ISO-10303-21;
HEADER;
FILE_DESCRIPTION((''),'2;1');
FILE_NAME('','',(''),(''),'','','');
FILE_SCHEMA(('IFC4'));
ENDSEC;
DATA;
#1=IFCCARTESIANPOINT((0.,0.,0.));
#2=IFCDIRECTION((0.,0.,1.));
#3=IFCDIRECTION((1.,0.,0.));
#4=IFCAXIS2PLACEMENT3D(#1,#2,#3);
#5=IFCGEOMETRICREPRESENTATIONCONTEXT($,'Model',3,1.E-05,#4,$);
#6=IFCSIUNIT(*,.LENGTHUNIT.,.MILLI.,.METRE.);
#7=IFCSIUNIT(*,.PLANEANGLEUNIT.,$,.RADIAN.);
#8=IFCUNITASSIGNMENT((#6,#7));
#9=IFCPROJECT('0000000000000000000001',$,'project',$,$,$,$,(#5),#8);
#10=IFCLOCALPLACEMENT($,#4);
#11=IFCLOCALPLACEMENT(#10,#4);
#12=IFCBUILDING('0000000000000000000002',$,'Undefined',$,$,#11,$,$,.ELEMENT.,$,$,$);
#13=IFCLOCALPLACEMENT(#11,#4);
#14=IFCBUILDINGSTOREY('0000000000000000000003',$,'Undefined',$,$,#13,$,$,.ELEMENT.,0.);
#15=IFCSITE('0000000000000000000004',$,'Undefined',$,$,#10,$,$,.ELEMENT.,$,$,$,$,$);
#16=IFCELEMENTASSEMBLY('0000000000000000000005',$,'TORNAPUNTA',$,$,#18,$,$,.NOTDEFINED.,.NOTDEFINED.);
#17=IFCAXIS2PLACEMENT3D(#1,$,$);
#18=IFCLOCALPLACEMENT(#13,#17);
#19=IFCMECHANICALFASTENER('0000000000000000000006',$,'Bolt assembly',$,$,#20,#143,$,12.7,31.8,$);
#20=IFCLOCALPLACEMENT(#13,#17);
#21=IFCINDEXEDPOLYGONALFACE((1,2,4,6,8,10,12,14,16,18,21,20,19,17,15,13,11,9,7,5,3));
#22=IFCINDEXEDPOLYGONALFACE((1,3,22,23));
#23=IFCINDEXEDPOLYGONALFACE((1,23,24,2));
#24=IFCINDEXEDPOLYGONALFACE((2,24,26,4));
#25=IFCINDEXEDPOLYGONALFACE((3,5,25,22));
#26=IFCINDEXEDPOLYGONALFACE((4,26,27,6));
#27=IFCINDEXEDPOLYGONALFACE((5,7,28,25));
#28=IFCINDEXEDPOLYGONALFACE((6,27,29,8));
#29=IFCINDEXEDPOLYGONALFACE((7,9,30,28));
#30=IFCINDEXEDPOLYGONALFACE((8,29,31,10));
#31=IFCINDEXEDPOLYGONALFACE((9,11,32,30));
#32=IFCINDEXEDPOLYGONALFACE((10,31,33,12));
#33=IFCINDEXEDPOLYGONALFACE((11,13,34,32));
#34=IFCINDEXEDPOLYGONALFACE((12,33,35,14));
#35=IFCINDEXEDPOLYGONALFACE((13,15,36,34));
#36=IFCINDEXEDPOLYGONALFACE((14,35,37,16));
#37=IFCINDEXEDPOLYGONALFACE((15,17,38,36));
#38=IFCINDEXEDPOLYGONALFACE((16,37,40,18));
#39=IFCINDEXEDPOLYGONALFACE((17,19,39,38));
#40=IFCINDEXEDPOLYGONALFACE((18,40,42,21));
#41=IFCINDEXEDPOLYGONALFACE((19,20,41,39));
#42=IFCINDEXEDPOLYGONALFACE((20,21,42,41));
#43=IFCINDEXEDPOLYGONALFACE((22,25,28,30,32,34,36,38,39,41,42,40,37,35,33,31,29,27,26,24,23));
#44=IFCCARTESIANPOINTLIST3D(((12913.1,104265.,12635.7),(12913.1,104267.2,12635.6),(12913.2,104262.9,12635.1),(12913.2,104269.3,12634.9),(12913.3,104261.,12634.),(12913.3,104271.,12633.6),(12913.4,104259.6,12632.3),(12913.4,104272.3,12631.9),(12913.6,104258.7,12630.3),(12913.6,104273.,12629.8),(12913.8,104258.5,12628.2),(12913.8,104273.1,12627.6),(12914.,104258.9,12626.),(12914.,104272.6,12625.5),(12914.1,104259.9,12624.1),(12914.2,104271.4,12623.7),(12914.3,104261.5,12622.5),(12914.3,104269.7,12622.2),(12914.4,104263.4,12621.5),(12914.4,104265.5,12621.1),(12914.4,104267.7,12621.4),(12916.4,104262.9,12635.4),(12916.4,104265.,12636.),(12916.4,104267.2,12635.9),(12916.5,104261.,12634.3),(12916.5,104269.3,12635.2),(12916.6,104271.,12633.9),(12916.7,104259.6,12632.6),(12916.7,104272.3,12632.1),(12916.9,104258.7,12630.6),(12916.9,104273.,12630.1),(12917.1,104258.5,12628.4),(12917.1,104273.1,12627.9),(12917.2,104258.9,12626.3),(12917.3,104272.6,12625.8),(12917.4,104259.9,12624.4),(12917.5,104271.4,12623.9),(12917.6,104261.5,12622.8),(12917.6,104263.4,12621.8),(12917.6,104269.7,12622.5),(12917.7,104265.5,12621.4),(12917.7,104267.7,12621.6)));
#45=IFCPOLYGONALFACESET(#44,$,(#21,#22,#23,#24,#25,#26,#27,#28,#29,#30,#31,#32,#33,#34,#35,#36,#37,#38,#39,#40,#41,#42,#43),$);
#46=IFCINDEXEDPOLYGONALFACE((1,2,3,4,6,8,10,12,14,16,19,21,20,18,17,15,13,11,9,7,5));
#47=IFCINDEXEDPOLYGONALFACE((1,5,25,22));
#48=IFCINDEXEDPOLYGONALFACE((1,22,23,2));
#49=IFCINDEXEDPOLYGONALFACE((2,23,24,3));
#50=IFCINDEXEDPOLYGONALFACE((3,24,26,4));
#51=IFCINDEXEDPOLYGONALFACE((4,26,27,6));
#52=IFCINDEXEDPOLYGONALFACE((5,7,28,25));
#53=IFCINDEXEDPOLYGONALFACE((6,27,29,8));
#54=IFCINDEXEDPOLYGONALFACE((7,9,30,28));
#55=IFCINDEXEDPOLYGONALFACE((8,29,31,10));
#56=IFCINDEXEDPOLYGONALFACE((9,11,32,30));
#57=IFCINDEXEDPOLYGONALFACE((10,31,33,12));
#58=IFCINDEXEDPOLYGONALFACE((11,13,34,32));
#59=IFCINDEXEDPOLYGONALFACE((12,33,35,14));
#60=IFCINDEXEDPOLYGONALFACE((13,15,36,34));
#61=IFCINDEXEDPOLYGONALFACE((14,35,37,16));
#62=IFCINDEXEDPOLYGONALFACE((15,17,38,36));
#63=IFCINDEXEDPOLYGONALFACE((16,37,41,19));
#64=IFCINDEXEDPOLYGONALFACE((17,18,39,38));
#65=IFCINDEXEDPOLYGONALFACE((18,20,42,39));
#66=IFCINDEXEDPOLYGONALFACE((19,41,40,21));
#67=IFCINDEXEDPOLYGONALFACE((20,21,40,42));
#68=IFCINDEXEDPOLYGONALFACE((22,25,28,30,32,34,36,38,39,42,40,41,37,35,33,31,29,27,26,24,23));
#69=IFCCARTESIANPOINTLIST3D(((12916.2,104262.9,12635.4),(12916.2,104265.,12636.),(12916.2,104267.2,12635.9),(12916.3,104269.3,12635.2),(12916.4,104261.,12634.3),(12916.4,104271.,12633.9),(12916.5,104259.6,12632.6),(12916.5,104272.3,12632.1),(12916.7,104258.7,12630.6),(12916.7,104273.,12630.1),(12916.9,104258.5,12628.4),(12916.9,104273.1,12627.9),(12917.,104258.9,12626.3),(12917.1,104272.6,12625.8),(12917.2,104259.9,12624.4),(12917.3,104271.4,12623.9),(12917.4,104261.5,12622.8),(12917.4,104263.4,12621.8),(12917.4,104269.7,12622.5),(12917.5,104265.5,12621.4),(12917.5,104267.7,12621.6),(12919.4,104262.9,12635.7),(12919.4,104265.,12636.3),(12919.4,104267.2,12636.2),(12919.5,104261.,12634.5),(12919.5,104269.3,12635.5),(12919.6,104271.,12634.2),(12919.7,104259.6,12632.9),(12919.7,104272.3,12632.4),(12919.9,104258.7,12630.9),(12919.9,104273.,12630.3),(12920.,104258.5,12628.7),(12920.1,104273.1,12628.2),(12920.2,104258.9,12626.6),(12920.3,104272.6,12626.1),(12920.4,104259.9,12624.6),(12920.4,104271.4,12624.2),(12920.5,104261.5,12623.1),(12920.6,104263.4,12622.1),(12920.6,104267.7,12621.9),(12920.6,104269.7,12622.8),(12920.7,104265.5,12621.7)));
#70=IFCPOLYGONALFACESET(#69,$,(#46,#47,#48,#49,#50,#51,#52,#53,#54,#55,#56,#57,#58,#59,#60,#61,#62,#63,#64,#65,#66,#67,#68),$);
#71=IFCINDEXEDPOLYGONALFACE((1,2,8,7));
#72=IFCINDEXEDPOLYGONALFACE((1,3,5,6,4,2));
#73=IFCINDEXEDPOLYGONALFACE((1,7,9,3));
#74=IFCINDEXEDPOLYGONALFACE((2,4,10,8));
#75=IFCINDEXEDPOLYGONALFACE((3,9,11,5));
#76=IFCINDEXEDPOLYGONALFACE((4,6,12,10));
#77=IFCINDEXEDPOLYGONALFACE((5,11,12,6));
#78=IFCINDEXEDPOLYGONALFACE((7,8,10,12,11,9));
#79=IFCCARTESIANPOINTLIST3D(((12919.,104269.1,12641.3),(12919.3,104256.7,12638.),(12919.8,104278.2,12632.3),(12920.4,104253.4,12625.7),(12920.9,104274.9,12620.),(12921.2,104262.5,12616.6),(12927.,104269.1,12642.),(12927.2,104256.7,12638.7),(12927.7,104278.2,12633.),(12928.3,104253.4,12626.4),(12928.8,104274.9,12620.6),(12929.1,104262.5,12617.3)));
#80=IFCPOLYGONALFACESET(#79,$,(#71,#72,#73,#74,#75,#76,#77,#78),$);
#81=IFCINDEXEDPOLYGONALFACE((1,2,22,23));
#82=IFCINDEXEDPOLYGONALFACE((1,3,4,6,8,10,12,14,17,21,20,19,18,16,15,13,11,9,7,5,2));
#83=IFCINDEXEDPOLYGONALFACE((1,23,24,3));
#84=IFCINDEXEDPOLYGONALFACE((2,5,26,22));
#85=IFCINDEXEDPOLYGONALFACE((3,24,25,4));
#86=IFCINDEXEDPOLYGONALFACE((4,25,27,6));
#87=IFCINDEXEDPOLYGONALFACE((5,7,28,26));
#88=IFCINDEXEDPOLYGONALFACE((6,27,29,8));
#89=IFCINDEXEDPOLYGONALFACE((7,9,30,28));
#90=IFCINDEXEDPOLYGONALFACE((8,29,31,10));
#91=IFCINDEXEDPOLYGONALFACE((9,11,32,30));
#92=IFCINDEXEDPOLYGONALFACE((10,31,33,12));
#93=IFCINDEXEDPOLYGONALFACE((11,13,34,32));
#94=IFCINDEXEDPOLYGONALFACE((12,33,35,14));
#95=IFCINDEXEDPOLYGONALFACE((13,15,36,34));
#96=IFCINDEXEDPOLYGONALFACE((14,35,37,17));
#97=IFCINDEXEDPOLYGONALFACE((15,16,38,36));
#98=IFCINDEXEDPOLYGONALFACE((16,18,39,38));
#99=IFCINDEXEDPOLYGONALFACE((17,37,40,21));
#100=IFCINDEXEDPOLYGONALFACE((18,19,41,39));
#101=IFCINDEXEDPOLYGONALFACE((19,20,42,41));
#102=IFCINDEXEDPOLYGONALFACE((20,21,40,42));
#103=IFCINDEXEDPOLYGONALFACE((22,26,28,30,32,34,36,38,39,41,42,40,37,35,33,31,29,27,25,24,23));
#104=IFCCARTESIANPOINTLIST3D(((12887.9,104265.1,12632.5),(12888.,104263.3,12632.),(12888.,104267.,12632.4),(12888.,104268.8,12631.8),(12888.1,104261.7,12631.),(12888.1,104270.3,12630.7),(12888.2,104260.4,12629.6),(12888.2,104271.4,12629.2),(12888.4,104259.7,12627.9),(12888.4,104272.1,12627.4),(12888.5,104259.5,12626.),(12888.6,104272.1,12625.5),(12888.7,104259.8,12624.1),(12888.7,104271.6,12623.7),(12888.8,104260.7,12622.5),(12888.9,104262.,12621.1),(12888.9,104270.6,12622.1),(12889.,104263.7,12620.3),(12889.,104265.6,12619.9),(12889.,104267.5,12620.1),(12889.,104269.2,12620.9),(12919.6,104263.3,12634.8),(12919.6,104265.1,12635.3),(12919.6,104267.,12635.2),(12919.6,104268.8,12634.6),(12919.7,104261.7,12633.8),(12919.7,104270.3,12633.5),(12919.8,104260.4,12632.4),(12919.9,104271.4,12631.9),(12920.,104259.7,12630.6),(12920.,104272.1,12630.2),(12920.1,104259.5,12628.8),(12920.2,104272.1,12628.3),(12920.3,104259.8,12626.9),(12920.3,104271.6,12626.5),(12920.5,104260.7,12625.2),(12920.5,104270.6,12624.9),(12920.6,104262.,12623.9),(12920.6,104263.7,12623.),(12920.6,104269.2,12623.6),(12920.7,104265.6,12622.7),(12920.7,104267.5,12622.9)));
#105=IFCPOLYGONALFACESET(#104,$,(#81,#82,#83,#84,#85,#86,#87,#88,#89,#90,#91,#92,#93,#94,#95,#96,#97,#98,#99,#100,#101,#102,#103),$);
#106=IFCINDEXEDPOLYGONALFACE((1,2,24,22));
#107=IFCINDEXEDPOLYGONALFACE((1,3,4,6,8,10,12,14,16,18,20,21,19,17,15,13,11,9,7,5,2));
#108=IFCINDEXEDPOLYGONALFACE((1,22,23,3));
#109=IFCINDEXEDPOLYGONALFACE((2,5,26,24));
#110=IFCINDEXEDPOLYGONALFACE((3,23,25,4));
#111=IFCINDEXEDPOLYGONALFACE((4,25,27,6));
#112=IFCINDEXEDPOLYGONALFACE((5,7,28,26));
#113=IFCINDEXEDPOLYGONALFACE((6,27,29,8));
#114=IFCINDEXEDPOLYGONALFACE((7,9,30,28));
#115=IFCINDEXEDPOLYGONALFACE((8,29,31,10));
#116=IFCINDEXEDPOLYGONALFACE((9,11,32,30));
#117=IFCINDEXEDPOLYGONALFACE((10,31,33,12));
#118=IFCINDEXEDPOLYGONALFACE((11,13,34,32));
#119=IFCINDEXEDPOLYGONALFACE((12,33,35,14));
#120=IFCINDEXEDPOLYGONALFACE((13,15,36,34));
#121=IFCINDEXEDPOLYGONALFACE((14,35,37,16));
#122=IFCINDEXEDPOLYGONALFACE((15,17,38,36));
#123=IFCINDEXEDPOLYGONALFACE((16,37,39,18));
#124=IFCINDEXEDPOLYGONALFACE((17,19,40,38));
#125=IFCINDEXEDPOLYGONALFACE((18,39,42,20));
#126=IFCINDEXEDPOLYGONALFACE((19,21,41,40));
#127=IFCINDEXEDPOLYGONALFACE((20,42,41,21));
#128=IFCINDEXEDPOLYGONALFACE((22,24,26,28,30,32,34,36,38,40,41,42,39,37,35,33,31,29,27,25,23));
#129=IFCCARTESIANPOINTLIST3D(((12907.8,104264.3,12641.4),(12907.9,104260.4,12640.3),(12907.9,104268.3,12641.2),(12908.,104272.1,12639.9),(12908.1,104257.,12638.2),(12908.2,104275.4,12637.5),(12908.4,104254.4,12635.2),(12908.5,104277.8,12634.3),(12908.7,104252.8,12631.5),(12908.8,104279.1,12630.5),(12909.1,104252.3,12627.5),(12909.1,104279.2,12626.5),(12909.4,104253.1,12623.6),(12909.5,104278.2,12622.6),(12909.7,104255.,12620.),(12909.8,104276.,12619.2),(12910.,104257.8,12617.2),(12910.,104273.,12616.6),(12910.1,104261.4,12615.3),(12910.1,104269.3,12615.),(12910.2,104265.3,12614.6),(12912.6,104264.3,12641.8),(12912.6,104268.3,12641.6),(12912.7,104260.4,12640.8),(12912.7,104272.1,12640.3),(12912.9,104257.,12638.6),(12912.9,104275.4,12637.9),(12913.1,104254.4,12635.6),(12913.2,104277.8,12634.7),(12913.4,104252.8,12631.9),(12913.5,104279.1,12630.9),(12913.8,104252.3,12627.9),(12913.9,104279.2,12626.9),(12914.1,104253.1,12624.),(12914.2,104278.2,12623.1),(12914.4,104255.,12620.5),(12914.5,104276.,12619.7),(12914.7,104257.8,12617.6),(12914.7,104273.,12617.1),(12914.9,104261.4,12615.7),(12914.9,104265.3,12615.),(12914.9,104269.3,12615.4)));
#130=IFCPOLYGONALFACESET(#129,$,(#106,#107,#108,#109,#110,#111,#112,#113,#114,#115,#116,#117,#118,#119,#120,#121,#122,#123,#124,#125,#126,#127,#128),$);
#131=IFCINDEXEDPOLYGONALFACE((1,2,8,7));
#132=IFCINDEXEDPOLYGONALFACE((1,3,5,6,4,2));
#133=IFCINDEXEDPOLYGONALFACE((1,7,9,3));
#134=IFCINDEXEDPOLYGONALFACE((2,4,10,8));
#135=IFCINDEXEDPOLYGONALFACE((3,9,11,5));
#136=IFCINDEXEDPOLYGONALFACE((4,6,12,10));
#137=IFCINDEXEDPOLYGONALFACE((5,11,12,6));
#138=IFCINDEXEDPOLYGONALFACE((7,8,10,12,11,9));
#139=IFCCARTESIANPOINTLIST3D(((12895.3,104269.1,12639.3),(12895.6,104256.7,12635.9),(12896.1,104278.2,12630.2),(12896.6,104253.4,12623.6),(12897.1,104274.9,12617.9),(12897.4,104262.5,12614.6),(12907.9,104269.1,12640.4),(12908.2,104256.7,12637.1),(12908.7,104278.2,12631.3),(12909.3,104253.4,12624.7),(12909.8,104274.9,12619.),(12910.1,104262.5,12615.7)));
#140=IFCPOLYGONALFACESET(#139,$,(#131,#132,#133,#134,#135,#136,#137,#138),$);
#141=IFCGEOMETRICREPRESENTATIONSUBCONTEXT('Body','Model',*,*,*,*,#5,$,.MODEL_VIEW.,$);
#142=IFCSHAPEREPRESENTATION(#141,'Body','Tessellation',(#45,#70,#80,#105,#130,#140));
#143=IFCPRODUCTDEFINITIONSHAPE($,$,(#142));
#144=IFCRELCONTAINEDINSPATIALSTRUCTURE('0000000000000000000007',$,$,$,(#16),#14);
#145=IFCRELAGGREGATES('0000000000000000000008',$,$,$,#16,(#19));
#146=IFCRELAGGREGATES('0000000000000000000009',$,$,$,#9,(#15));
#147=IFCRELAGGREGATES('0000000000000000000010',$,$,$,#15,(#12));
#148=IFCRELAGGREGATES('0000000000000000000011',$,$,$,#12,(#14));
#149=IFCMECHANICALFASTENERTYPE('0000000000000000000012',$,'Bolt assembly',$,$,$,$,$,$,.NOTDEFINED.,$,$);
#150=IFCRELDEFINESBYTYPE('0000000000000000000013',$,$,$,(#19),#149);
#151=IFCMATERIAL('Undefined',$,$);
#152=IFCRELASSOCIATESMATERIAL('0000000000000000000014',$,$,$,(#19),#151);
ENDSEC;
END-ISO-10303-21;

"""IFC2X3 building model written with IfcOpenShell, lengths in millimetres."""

from ifc_helpers import new_model, si_unit, frame, origin_with_axes, origin_2d_with_axis, place, context, subcontext, project, spatial, polyline, circle, outline, extrude, source, transform, mapped, material, type_object, element, aggregate, save


model = new_model("IFC2X3")

# Units and contexts
model_context = context("Model", 3, precision=1e-05, world=origin_with_axes())
body_context = subcontext(model_context, "Body", "Model", "MODEL_VIEW")
ifc_project = project(units=[si_unit("LENGTHUNIT", "METRE", prefix="MILLI"), si_unit("PLANEANGLEUNIT", "RADIAN")], contexts=[model_context])

# Site, building, storey
site_placement = place(None, origin_with_axes())
site = spatial("IfcSite", under=ifc_project, at=site_placement, Name="Undefined", CompositionType="ELEMENT")
building_placement = place(site_placement, origin_with_axes())
building = spatial("IfcBuilding", under=site, at=building_placement, Name="Undefined", CompositionType="ELEMENT")
storey_placement = place(building_placement, origin_with_axes())
storey = spatial("IfcBuildingStorey", under=building, at=storey_placement, Name="Undefined", CompositionType="ELEMENT", Elevation=0.0)

# Element assembly
assembly_1_placement = place(storey_placement, origin_with_axes())
assembly_1 = element("IfcElementAssembly", 1, at=assembly_1_placement, inside=storey, Name="TORNAPUNTA", AssemblyPlace="NOTDEFINED", PredefinedType="NOTDEFINED")

# Mechanical fastener
ifc_material_1 = material(Name="Undefined")
mechanical_fastener_type = type_object("IfcMechanicalFastenerType", Name="Bolt assembly")
shared_shape_1 = source(origin_with_axes(), body_context, "Body", "SweptSolid", [
    extrude(circle(Radius=7.3, at=origin_2d_with_axis()), frame((0.0, -0.1, 0.0), z_axis=(0.0, 1.0, 0.0), x_axis=(1.0, 0.0, 0.0)), (0.0, 0.0, 1.0), 3.3),
    extrude(circle(Radius=7.3, at=origin_2d_with_axis()), frame((0.0, -3.1, 0.0), z_axis=(0.0, 1.0, 0.0), x_axis=(1.0, 0.0, 0.0)), (0.0, 0.0, 1.0), 3.2),
    extrude(outline(polyline([(11.1, -6.4), (11.1, 6.4), (0.0, 12.8), (-11.1, 6.4), (-11.1, -6.4), (0.0, -12.8), (11.1, -6.4)])), frame((0.0, -11.1, 0.0), z_axis=(0.0, 1.0, 0.0), x_axis=(1.0, 0.0, 0.0)), (0.0, 0.0, 1.0), 7.9),
    extrude(circle(Radius=6.3, at=origin_2d_with_axis()), frame((0.0, -3.2, 0.0), z_axis=(0.0, 1.0, 0.0), x_axis=(1.0, 0.0, 0.0)), (0.0, 0.0, 1.0), 31.8),
    extrude(circle(Radius=13.5, at=origin_2d_with_axis()), frame((0.0, 3.2, 0.0), z_axis=(0.0, 1.0, 0.0), x_axis=(1.0, 0.0, 0.0)), (0.0, 0.0, 1.0), 4.8),
    extrude(outline(polyline([(11.1, -6.4), (11.1, 6.4), (0.0, 12.8), (-11.1, 6.4), (-11.1, -6.4), (0.0, -12.8), (11.1, -6.4)])), frame((0.0, 8.0, 0.0), z_axis=(0.0, 1.0, 0.0), x_axis=(1.0, 0.0, 0.0)), (0.0, 0.0, 1.0), 12.7),
])
mechanical_fastener_1_placement = place(assembly_1_placement, frame((12916.9, 104265.8, 12628.7), z_axis=(-0.061628, -0.707107, 0.704416), x_axis=(-0.061628, 0.707107, 0.704416)))
mechanical_fastener_1 = element("IfcMechanicalFastener", 2, at=mechanical_fastener_1_placement, type_object=mechanical_fastener_type, material=ifc_material_1, Name="Bolt assembly", NominalDiameter=12.7, NominalLength=31.8, context=body_context, shape_type="MappedRepresentation", body=[
    mapped(shared_shape_1, transform((0.0, 0.0, 0.0))),
])
aggregate(assembly_1, [mechanical_fastener_1])

save(model, "model.ifc")
